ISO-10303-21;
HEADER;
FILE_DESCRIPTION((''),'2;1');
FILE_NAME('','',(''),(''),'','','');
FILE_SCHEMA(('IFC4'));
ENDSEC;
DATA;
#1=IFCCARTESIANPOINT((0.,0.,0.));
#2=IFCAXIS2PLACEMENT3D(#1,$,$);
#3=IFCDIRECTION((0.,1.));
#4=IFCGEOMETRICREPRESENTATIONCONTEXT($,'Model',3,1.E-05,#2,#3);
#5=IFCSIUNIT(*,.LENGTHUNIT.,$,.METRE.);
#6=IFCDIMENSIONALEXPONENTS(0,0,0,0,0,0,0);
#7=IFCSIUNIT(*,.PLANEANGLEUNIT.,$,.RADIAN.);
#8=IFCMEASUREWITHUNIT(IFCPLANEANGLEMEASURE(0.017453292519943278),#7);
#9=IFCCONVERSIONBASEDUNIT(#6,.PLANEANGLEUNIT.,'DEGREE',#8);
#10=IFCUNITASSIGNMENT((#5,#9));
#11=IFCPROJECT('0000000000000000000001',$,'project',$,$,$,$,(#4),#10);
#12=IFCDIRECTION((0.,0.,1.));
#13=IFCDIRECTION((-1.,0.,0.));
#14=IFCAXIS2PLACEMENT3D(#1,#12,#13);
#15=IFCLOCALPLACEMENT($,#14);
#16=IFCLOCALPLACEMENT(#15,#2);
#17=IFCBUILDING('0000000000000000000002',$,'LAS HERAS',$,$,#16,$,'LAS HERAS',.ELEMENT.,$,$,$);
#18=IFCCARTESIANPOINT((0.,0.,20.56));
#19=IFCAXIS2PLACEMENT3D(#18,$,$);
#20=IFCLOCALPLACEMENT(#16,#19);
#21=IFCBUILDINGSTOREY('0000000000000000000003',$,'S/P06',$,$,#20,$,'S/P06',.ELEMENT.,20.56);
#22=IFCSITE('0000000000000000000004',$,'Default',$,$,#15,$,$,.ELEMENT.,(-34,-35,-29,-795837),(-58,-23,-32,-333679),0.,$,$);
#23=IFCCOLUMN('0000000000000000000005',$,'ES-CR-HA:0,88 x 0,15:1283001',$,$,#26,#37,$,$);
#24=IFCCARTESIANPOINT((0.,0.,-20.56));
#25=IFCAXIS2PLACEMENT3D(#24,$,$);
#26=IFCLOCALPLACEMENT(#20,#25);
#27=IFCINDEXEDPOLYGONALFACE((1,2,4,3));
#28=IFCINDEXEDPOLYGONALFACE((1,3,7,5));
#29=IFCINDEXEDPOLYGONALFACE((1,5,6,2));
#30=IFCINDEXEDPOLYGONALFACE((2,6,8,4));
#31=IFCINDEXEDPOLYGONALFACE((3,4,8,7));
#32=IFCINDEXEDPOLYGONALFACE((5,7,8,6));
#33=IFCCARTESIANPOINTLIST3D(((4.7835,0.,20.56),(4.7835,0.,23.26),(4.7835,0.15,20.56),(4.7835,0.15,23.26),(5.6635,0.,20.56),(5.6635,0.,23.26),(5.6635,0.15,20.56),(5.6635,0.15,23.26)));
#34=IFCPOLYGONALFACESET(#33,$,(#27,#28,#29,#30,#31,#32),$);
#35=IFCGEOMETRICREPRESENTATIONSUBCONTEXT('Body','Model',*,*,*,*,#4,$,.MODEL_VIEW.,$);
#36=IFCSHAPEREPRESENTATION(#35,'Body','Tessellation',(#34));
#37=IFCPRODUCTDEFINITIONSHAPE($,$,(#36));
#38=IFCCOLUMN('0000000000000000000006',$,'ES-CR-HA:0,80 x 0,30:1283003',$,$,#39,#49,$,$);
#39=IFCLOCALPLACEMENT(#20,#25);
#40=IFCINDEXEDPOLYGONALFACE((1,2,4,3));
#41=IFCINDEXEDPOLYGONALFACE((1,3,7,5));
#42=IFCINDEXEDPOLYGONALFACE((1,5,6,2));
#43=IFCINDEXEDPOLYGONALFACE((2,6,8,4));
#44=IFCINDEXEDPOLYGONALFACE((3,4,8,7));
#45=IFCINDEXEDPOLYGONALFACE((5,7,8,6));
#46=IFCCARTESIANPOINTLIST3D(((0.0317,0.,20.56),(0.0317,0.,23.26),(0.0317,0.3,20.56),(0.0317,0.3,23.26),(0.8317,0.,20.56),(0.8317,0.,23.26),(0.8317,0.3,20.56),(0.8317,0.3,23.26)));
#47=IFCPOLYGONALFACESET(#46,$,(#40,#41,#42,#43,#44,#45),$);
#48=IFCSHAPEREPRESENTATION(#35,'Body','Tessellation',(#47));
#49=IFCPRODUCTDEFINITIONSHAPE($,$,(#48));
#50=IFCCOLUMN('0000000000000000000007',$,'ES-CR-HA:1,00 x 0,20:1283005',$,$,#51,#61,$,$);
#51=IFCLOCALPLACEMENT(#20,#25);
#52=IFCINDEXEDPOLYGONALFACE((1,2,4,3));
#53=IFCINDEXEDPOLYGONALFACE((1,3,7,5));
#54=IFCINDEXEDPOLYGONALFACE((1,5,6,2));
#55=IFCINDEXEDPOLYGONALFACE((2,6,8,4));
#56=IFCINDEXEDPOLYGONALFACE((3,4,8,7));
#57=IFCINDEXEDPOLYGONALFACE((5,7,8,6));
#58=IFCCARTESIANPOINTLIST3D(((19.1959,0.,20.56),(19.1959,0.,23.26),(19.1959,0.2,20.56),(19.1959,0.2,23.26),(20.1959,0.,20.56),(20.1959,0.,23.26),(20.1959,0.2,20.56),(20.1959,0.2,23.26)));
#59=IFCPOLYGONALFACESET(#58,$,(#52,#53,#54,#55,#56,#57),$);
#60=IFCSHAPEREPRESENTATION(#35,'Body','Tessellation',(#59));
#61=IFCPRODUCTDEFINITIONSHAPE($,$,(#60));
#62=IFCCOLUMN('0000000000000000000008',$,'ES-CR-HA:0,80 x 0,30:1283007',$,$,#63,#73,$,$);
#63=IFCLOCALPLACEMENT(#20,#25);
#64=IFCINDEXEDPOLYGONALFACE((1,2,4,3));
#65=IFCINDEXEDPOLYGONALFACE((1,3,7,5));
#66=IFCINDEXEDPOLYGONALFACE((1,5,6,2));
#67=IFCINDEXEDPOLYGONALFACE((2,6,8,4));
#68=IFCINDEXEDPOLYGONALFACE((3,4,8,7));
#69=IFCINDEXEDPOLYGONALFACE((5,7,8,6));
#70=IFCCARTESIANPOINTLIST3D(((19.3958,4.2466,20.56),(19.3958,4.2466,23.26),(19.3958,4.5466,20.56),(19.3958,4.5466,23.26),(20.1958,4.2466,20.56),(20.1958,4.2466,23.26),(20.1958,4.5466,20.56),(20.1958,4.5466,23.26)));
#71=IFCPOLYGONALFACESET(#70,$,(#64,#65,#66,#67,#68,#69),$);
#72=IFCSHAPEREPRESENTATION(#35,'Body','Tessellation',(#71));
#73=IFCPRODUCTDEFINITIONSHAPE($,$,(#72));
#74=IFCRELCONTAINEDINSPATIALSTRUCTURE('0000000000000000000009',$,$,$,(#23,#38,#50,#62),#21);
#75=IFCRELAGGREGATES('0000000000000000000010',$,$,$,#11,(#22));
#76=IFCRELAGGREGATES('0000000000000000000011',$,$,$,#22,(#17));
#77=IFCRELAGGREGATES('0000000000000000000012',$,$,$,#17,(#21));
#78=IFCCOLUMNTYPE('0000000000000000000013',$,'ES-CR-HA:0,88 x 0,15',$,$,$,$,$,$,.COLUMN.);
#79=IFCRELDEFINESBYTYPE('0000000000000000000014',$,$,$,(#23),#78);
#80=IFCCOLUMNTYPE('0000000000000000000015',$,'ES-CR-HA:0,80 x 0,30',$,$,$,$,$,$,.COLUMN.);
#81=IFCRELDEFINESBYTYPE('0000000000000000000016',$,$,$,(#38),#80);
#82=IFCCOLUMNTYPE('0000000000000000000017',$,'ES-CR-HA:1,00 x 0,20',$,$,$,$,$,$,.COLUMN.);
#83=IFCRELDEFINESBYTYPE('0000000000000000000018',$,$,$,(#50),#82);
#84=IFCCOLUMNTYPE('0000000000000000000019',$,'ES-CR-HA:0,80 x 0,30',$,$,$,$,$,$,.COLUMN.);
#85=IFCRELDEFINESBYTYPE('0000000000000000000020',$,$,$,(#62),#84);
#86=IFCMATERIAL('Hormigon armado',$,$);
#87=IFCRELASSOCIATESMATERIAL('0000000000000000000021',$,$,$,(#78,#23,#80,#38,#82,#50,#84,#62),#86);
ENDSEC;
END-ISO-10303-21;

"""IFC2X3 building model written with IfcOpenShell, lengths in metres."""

from ifc_helpers import new_model, entity, si_unit, converted_unit, direction, frame, frame_2d, origin, origin_2d_with_axis, place, context, subcontext, project, spatial, rectangle, extrude, source, transform, mapped, material, type_object, type_shapes, element, save


model = new_model("IFC2X3")

# Units and contexts
model_context = context("Model", 3, precision=1e-05, world=origin(), true_north=direction((0.0, 1.0)))
body_context = subcontext(model_context, "Body", "Model", "MODEL_VIEW")
ifc_project = project(units=[si_unit("LENGTHUNIT", "METRE"), converted_unit("PLANEANGLEUNIT", "DEGREE", entity("IfcPlaneAngleMeasure", 0.017453292519943278), si_unit("PLANEANGLEUNIT", "RADIAN"), dimensions=[0, 0, 0, 0, 0, 0, 0])], contexts=[model_context])

# Site, building, storey
site_placement = place(None, frame((0.0, 0.0, 0.0), z_axis=(0.0, 0.0, 1.0), x_axis=(-1.0, 0.0, 0.0)))
site = spatial("IfcSite", under=ifc_project, at=site_placement, Name="Default", CompositionType="ELEMENT", RefLatitude=(-34, -35, -29, -795837), RefLongitude=(-58, -23, -32, -333679), RefElevation=0.0)
building_placement = place(site_placement, origin())
building = spatial("IfcBuilding", under=site, at=building_placement, Name="LAS HERAS", LongName="LAS HERAS", CompositionType="ELEMENT")
storey_placement = place(building_placement, frame((0.0, 0.0, 20.56)))
storey = spatial("IfcBuildingStorey", under=building, at=storey_placement, Name="S/P06", LongName="S/P06", CompositionType="ELEMENT", Elevation=20.56)

# Columns
ifc_material = material(Name="Hormigon armado")
column_type_1 = type_object("IfcColumnType", Name="ES-CR-HA:0,88 x 0,15", PredefinedType="COLUMN", material=ifc_material)
shared_shape_1 = source(origin(), body_context, "Body", "SweptSolid", [
    extrude(rectangle(XDim=2.7, YDim=0.15, at=frame_2d((0.0, 0.0), x_axis=(1.0, 0.0))), frame((4.7835, 0.075, 21.91), z_axis=(1.0, 0.0, 0.0), x_axis=(0.0, 0.0, 1.0)), (0.0, 0.0, 1.0), 0.88),
])
type_shapes(column_type_1, [shared_shape_1])
column_1_placement = place(storey_placement, frame((0.0, 0.0, -20.56)))
element("IfcColumn", 1, at=column_1_placement, inside=storey, type_object=column_type_1, material=ifc_material, Name="ES-CR-HA:0,88 x 0,15:1283001", context=body_context, shape_type="MappedRepresentation", body=[
    mapped(shared_shape_1, transform((0.0, 0.0, 0.0), scale=1.0)),
])
column_type_2 = type_object("IfcColumnType", Name="ES-CR-HA:0,80 x 0,30", PredefinedType="COLUMN", material=ifc_material)
shared_shape_2 = source(origin(), body_context, "Body", "SweptSolid", [
    extrude(rectangle(XDim=2.7, YDim=0.3, at=origin_2d_with_axis()), frame((0.0317, 0.15, 21.91), z_axis=(1.0, 0.0, 0.0), x_axis=(0.0, 0.0, 1.0)), (0.0, 0.0, 1.0), 0.8),
])
type_shapes(column_type_2, [shared_shape_2])
column_2_placement = place(storey_placement, frame((0.0, 0.0, -20.56)))
element("IfcColumn", 2, at=column_2_placement, inside=storey, type_object=column_type_2, material=ifc_material, Name="ES-CR-HA:0,80 x 0,30:1283003", context=body_context, shape_type="MappedRepresentation", body=[
    mapped(shared_shape_2, transform((0.0, 0.0, 0.0), scale=1.0)),
])
column_type_3 = type_object("IfcColumnType", Name="ES-CR-HA:1,00 x 0,20", PredefinedType="COLUMN", material=ifc_material)
shared_shape_3 = source(origin(), body_context, "Body", "SweptSolid", [
    extrude(rectangle(XDim=2.7, YDim=0.2, at=frame_2d((0.0, 0.0), x_axis=(1.0, 0.0))), frame((19.1959, 0.1, 21.91), z_axis=(1.0, 0.0, 0.0), x_axis=(0.0, 0.0, 1.0)), (0.0, 0.0, 1.0), 1.0),
])
type_shapes(column_type_3, [shared_shape_3])
column_3_placement = place(storey_placement, frame((0.0, 0.0, -20.56)))
element("IfcColumn", 3, at=column_3_placement, inside=storey, type_object=column_type_3, material=ifc_material, Name="ES-CR-HA:1,00 x 0,20:1283005", context=body_context, shape_type="MappedRepresentation", body=[
    mapped(shared_shape_3, transform((0.0, 0.0, 0.0), scale=1.0)),
])
column_type_4 = type_object("IfcColumnType", Name="ES-CR-HA:0,80 x 0,30", PredefinedType="COLUMN", material=ifc_material)
shared_shape_4 = source(origin(), body_context, "Body", "SweptSolid", [
    extrude(rectangle(XDim=2.7, YDim=0.3, at=origin_2d_with_axis()), frame((19.3958, 4.3966, 21.91), z_axis=(1.0, 0.0, 0.0), x_axis=(0.0, 0.0, 1.0)), (0.0, 0.0, 1.0), 0.8),
])
type_shapes(column_type_4, [shared_shape_4])
column_4_placement = place(storey_placement, frame((0.0, 0.0, -20.56)))
element("IfcColumn", 4, at=column_4_placement, inside=storey, type_object=column_type_4, material=ifc_material, Name="ES-CR-HA:0,80 x 0,30:1283007", context=body_context, shape_type="MappedRepresentation", body=[
    mapped(shared_shape_4, transform((0.0, 0.0, 0.0), scale=1.0)),
])

save(model, "model.ifc")
